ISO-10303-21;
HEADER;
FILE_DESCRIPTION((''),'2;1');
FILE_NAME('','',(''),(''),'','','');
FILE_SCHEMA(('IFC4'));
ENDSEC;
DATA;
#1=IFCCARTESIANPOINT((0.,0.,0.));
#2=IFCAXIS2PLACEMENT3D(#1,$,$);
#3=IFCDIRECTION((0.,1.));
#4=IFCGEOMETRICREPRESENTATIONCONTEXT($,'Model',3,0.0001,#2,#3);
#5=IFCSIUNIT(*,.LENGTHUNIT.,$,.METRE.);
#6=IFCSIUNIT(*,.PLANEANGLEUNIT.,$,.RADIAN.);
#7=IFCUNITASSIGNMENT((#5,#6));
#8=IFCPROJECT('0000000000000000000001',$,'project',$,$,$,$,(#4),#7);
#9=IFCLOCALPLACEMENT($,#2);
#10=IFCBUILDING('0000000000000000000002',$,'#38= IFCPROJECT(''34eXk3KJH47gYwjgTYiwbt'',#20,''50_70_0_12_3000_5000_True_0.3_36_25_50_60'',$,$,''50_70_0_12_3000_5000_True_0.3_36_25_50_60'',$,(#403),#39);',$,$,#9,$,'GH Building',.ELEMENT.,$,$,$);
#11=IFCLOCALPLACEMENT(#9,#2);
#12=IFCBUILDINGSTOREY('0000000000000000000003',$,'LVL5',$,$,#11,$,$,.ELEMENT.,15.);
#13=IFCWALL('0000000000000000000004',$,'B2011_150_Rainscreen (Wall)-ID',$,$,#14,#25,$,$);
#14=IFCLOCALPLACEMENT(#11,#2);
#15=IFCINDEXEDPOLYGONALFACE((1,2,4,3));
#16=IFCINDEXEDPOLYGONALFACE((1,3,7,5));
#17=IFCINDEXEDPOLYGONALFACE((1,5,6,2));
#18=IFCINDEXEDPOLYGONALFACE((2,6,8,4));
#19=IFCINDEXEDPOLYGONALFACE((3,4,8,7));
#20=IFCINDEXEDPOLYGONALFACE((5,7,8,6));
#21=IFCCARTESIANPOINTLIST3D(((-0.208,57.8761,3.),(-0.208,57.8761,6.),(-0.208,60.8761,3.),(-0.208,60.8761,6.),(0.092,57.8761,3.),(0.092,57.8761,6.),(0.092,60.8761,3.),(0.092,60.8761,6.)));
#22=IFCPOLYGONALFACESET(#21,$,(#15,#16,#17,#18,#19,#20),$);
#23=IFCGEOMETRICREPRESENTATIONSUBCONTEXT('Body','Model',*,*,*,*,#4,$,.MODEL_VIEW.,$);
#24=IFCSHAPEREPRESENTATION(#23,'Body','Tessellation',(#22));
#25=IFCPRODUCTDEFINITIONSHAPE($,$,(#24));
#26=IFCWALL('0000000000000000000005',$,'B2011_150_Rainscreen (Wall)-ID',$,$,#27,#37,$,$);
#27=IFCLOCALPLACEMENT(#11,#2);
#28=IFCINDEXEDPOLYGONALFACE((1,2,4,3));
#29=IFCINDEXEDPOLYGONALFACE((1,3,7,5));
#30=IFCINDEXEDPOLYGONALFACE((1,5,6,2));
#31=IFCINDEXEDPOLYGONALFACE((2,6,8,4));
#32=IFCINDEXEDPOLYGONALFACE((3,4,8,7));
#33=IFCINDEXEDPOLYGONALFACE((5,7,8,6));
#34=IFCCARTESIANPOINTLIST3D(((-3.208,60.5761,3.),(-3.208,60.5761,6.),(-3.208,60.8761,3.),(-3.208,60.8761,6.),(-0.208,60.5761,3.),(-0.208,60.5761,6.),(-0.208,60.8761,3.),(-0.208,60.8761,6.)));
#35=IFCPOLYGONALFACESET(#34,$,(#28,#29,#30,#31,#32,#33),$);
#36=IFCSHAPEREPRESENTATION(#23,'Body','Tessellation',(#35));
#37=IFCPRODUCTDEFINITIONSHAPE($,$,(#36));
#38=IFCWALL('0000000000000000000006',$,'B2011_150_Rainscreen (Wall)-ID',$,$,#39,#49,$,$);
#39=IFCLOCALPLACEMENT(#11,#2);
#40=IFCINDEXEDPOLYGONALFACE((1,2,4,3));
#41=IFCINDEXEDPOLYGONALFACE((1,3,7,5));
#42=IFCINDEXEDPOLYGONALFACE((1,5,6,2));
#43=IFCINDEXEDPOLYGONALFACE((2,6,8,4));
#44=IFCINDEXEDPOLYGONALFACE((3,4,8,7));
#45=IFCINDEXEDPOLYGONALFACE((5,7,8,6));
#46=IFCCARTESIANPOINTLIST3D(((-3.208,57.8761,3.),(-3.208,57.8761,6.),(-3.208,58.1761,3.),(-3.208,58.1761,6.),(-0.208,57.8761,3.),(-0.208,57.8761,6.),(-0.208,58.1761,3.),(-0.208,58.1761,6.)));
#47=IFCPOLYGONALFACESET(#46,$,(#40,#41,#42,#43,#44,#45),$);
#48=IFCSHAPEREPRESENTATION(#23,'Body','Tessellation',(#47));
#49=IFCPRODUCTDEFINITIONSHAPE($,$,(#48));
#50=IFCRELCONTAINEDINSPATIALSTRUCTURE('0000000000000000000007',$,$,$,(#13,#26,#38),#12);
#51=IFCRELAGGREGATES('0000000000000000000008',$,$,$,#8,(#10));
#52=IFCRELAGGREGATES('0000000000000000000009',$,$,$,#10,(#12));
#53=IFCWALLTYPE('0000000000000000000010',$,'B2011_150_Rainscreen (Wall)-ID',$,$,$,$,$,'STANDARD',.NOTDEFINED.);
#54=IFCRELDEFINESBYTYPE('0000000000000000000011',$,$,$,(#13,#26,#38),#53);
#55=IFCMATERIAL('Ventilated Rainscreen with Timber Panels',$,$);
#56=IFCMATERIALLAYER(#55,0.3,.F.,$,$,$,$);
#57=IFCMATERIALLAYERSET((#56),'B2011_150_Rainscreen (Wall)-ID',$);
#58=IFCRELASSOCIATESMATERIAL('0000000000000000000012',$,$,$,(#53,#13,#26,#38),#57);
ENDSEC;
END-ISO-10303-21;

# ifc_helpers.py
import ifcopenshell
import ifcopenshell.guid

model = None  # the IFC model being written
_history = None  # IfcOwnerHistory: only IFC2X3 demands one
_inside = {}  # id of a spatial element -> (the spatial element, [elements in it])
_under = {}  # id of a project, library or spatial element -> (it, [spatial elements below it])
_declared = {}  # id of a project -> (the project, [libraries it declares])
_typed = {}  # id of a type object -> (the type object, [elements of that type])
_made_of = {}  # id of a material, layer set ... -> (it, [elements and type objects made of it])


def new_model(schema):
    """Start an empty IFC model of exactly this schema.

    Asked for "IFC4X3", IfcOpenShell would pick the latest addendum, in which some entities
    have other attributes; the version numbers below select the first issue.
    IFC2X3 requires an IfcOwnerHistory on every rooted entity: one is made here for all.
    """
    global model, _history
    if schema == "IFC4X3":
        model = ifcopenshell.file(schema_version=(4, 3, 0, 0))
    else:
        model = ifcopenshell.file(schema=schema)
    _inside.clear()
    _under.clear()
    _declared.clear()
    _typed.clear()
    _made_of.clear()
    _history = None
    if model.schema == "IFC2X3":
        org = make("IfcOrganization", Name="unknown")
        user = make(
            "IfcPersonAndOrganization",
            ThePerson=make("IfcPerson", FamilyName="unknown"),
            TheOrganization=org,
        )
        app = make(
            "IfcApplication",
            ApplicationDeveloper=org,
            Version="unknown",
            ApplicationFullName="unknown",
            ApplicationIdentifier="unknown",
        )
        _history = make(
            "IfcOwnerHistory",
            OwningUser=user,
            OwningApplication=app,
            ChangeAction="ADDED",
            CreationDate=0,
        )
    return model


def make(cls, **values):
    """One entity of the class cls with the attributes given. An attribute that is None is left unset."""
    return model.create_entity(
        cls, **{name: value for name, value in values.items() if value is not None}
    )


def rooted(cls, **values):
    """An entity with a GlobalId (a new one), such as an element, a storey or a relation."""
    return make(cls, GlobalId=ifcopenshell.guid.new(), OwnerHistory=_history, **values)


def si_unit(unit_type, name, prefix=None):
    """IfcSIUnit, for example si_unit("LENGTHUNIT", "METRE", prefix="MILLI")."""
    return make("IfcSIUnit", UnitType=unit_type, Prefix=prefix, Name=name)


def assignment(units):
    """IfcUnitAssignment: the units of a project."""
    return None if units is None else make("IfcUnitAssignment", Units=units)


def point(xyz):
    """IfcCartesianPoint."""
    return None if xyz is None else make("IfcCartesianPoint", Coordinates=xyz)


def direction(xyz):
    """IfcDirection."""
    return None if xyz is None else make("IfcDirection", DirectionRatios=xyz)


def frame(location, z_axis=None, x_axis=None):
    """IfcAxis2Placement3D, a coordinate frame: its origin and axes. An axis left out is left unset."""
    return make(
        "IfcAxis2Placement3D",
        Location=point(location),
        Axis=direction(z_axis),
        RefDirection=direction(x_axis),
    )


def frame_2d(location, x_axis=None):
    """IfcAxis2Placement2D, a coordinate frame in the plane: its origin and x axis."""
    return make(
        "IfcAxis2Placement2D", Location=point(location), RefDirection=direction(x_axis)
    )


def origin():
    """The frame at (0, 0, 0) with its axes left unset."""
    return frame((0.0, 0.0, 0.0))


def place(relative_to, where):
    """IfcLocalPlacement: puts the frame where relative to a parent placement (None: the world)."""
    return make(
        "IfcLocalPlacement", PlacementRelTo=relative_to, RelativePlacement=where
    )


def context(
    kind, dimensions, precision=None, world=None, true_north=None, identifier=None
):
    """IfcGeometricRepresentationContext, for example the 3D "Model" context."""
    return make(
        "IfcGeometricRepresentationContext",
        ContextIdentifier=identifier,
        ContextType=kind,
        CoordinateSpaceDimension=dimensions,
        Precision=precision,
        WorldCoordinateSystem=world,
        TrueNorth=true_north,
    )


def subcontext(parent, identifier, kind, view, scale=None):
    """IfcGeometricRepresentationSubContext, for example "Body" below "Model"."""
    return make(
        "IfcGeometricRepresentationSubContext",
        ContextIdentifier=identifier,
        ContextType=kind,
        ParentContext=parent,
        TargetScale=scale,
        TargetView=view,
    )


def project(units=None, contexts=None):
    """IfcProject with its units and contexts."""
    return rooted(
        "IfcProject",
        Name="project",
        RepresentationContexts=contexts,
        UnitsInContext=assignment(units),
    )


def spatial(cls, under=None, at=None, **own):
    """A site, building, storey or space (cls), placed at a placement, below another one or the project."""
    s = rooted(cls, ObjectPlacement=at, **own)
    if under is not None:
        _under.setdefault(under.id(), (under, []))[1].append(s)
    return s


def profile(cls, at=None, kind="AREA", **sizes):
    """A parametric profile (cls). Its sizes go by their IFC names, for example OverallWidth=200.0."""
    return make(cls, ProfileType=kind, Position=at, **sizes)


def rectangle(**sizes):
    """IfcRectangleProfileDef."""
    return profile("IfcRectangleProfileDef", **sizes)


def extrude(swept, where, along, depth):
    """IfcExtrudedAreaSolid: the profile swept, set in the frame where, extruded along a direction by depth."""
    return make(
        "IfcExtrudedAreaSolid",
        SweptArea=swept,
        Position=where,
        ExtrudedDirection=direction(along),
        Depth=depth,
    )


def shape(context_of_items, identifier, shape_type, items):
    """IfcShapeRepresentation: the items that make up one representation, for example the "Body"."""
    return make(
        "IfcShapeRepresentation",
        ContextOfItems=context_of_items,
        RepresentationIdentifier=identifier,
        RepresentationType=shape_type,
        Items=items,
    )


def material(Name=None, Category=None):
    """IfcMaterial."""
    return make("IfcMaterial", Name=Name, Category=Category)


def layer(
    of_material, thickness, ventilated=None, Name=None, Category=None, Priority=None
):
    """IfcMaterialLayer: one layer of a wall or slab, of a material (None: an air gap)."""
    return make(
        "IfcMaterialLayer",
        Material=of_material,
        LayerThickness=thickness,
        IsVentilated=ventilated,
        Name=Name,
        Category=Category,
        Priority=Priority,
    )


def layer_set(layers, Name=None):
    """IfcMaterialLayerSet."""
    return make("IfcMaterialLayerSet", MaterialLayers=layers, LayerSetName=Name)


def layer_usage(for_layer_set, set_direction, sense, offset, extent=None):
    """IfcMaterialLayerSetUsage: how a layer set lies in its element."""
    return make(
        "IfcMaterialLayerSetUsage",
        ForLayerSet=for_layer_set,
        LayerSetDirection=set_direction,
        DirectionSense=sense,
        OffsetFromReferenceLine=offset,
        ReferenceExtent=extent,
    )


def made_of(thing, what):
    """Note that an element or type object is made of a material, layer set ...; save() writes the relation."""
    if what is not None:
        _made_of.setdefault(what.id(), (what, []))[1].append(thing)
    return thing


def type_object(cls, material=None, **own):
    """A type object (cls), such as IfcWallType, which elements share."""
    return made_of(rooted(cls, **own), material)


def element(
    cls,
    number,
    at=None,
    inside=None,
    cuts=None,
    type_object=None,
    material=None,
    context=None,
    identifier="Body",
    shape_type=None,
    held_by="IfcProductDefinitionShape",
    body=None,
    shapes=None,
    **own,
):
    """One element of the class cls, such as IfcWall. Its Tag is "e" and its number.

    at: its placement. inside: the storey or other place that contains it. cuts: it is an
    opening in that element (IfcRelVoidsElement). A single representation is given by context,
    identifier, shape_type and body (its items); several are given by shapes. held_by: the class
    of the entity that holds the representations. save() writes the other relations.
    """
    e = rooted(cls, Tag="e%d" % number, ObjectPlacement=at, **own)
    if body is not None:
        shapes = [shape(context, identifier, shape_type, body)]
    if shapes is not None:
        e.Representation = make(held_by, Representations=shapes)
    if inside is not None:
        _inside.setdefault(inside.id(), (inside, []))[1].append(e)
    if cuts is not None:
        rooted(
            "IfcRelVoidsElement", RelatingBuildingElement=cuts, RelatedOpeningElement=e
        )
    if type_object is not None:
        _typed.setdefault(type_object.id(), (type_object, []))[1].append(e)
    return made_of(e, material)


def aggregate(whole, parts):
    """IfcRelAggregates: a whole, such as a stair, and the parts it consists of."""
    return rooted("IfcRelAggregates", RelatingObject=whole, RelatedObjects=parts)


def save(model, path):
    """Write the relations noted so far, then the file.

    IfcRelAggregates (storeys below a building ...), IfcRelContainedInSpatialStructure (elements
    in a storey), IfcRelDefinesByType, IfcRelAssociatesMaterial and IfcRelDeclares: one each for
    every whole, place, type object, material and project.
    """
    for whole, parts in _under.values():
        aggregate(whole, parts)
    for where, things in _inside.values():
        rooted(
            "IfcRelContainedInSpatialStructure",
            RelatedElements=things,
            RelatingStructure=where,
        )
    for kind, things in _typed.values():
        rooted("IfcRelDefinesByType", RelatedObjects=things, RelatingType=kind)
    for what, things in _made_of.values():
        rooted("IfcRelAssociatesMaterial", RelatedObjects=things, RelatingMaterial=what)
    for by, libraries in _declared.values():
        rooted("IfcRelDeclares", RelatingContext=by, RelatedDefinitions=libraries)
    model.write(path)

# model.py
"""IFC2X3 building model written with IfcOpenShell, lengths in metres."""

from ifc_helpers import new_model, si_unit, direction, frame, frame_2d, origin, place, context, subcontext, project, spatial, rectangle, extrude, material, layer, layer_set, layer_usage, type_object, element, save


model = new_model("IFC2X3")

# Units and contexts
model_context = context("Model", 3, precision=0.0001, world=origin(), true_north=direction((0.0, 1.0)))
body_context = subcontext(model_context, "Body", "Model", "MODEL_VIEW")
ifc_project = project(units=[si_unit("LENGTHUNIT", "METRE"), si_unit("PLANEANGLEUNIT", "RADIAN")], contexts=[model_context])

# Building, storey
building_placement = place(None, origin())
building = spatial("IfcBuilding", under=ifc_project, at=building_placement, Name="#38= IFCPROJECT('34eXk3KJH47gYwjgTYiwbt',#20,'50_70_0_12_3000_5000_True_0.3_36_25_50_60',$,$,'50_70_0_12_3000_5000_True_0.3_36_25_50_60',$,(#403),#39);", LongName="GH Building", CompositionType="ELEMENT")
storey_placement = place(building_placement, origin())
storey = spatial("IfcBuildingStorey", under=building, at=storey_placement, Name="LVL5", CompositionType="ELEMENT", Elevation=15.0)

# Walls
ifc_material_1 = material(Name="Ventilated Rainscreen with Timber Panels")
ifc_layer_1 = layer(ifc_material_1, 0.3, ventilated=False)
ifc_layer_set_1 = layer_set([ifc_layer_1], Name="B2011_150_Rainscreen (Wall)-ID")
ifc_layer_usage_1 = layer_usage(ifc_layer_set_1, "AXIS2", "POSITIVE", 0.0)
wall_type = type_object("IfcWallType", Name="B2011_150_Rainscreen (Wall)-ID", ElementType="STANDARD", PredefinedType="NOTDEFINED", material=ifc_layer_set_1)
wall_1_placement = place(storey_placement, frame((-0.208, 60.8761, 3.0), z_axis=(0.0, 0.0, 1.0), x_axis=(0.0, -1.0, 0.0)))
element("IfcWall", 1, at=wall_1_placement, inside=storey, type_object=wall_type, material=ifc_layer_usage_1, Name="B2011_150_Rainscreen (Wall)-ID", context=body_context, shape_type="SweptSolid", body=[
    extrude(rectangle(XDim=3.0, YDim=0.3, at=frame_2d((1.5, 0.15))), origin(), (0.0, 0.0, 1.0), 3.0),
])
ifc_layer_usage_2 = layer_usage(ifc_layer_set_1, "AXIS2", "POSITIVE", 0.0)
wall_2_placement = place(storey_placement, frame((-0.208, 60.8761, 3.0), z_axis=(0.0, 0.0, 1.0), x_axis=(-1.0, 0.0, 0.0)))
element("IfcWall", 2, at=wall_2_placement, inside=storey, type_object=wall_type, material=ifc_layer_usage_2, Name="B2011_150_Rainscreen (Wall)-ID", context=body_context, shape_type="SweptSolid", body=[
    extrude(rectangle(XDim=3.0, YDim=0.3, at=frame_2d((1.5, 0.15))), origin(), (0.0, 0.0, 1.0), 3.0),
])
ifc_layer_usage_3 = layer_usage(ifc_layer_set_1, "AXIS2", "POSITIVE", 0.0)
wall_3_placement = place(storey_placement, frame((-3.208, 57.8761, 3.0)))
element("IfcWall", 3, at=wall_3_placement, inside=storey, type_object=wall_type, material=ifc_layer_usage_3, Name="B2011_150_Rainscreen (Wall)-ID", context=body_context, shape_type="SweptSolid", body=[
    extrude(rectangle(XDim=3.0, YDim=0.3, at=frame_2d((1.5, 0.15))), origin(), (0.0, 0.0, 1.0), 3.0),
])

save(model, "model.ifc")
